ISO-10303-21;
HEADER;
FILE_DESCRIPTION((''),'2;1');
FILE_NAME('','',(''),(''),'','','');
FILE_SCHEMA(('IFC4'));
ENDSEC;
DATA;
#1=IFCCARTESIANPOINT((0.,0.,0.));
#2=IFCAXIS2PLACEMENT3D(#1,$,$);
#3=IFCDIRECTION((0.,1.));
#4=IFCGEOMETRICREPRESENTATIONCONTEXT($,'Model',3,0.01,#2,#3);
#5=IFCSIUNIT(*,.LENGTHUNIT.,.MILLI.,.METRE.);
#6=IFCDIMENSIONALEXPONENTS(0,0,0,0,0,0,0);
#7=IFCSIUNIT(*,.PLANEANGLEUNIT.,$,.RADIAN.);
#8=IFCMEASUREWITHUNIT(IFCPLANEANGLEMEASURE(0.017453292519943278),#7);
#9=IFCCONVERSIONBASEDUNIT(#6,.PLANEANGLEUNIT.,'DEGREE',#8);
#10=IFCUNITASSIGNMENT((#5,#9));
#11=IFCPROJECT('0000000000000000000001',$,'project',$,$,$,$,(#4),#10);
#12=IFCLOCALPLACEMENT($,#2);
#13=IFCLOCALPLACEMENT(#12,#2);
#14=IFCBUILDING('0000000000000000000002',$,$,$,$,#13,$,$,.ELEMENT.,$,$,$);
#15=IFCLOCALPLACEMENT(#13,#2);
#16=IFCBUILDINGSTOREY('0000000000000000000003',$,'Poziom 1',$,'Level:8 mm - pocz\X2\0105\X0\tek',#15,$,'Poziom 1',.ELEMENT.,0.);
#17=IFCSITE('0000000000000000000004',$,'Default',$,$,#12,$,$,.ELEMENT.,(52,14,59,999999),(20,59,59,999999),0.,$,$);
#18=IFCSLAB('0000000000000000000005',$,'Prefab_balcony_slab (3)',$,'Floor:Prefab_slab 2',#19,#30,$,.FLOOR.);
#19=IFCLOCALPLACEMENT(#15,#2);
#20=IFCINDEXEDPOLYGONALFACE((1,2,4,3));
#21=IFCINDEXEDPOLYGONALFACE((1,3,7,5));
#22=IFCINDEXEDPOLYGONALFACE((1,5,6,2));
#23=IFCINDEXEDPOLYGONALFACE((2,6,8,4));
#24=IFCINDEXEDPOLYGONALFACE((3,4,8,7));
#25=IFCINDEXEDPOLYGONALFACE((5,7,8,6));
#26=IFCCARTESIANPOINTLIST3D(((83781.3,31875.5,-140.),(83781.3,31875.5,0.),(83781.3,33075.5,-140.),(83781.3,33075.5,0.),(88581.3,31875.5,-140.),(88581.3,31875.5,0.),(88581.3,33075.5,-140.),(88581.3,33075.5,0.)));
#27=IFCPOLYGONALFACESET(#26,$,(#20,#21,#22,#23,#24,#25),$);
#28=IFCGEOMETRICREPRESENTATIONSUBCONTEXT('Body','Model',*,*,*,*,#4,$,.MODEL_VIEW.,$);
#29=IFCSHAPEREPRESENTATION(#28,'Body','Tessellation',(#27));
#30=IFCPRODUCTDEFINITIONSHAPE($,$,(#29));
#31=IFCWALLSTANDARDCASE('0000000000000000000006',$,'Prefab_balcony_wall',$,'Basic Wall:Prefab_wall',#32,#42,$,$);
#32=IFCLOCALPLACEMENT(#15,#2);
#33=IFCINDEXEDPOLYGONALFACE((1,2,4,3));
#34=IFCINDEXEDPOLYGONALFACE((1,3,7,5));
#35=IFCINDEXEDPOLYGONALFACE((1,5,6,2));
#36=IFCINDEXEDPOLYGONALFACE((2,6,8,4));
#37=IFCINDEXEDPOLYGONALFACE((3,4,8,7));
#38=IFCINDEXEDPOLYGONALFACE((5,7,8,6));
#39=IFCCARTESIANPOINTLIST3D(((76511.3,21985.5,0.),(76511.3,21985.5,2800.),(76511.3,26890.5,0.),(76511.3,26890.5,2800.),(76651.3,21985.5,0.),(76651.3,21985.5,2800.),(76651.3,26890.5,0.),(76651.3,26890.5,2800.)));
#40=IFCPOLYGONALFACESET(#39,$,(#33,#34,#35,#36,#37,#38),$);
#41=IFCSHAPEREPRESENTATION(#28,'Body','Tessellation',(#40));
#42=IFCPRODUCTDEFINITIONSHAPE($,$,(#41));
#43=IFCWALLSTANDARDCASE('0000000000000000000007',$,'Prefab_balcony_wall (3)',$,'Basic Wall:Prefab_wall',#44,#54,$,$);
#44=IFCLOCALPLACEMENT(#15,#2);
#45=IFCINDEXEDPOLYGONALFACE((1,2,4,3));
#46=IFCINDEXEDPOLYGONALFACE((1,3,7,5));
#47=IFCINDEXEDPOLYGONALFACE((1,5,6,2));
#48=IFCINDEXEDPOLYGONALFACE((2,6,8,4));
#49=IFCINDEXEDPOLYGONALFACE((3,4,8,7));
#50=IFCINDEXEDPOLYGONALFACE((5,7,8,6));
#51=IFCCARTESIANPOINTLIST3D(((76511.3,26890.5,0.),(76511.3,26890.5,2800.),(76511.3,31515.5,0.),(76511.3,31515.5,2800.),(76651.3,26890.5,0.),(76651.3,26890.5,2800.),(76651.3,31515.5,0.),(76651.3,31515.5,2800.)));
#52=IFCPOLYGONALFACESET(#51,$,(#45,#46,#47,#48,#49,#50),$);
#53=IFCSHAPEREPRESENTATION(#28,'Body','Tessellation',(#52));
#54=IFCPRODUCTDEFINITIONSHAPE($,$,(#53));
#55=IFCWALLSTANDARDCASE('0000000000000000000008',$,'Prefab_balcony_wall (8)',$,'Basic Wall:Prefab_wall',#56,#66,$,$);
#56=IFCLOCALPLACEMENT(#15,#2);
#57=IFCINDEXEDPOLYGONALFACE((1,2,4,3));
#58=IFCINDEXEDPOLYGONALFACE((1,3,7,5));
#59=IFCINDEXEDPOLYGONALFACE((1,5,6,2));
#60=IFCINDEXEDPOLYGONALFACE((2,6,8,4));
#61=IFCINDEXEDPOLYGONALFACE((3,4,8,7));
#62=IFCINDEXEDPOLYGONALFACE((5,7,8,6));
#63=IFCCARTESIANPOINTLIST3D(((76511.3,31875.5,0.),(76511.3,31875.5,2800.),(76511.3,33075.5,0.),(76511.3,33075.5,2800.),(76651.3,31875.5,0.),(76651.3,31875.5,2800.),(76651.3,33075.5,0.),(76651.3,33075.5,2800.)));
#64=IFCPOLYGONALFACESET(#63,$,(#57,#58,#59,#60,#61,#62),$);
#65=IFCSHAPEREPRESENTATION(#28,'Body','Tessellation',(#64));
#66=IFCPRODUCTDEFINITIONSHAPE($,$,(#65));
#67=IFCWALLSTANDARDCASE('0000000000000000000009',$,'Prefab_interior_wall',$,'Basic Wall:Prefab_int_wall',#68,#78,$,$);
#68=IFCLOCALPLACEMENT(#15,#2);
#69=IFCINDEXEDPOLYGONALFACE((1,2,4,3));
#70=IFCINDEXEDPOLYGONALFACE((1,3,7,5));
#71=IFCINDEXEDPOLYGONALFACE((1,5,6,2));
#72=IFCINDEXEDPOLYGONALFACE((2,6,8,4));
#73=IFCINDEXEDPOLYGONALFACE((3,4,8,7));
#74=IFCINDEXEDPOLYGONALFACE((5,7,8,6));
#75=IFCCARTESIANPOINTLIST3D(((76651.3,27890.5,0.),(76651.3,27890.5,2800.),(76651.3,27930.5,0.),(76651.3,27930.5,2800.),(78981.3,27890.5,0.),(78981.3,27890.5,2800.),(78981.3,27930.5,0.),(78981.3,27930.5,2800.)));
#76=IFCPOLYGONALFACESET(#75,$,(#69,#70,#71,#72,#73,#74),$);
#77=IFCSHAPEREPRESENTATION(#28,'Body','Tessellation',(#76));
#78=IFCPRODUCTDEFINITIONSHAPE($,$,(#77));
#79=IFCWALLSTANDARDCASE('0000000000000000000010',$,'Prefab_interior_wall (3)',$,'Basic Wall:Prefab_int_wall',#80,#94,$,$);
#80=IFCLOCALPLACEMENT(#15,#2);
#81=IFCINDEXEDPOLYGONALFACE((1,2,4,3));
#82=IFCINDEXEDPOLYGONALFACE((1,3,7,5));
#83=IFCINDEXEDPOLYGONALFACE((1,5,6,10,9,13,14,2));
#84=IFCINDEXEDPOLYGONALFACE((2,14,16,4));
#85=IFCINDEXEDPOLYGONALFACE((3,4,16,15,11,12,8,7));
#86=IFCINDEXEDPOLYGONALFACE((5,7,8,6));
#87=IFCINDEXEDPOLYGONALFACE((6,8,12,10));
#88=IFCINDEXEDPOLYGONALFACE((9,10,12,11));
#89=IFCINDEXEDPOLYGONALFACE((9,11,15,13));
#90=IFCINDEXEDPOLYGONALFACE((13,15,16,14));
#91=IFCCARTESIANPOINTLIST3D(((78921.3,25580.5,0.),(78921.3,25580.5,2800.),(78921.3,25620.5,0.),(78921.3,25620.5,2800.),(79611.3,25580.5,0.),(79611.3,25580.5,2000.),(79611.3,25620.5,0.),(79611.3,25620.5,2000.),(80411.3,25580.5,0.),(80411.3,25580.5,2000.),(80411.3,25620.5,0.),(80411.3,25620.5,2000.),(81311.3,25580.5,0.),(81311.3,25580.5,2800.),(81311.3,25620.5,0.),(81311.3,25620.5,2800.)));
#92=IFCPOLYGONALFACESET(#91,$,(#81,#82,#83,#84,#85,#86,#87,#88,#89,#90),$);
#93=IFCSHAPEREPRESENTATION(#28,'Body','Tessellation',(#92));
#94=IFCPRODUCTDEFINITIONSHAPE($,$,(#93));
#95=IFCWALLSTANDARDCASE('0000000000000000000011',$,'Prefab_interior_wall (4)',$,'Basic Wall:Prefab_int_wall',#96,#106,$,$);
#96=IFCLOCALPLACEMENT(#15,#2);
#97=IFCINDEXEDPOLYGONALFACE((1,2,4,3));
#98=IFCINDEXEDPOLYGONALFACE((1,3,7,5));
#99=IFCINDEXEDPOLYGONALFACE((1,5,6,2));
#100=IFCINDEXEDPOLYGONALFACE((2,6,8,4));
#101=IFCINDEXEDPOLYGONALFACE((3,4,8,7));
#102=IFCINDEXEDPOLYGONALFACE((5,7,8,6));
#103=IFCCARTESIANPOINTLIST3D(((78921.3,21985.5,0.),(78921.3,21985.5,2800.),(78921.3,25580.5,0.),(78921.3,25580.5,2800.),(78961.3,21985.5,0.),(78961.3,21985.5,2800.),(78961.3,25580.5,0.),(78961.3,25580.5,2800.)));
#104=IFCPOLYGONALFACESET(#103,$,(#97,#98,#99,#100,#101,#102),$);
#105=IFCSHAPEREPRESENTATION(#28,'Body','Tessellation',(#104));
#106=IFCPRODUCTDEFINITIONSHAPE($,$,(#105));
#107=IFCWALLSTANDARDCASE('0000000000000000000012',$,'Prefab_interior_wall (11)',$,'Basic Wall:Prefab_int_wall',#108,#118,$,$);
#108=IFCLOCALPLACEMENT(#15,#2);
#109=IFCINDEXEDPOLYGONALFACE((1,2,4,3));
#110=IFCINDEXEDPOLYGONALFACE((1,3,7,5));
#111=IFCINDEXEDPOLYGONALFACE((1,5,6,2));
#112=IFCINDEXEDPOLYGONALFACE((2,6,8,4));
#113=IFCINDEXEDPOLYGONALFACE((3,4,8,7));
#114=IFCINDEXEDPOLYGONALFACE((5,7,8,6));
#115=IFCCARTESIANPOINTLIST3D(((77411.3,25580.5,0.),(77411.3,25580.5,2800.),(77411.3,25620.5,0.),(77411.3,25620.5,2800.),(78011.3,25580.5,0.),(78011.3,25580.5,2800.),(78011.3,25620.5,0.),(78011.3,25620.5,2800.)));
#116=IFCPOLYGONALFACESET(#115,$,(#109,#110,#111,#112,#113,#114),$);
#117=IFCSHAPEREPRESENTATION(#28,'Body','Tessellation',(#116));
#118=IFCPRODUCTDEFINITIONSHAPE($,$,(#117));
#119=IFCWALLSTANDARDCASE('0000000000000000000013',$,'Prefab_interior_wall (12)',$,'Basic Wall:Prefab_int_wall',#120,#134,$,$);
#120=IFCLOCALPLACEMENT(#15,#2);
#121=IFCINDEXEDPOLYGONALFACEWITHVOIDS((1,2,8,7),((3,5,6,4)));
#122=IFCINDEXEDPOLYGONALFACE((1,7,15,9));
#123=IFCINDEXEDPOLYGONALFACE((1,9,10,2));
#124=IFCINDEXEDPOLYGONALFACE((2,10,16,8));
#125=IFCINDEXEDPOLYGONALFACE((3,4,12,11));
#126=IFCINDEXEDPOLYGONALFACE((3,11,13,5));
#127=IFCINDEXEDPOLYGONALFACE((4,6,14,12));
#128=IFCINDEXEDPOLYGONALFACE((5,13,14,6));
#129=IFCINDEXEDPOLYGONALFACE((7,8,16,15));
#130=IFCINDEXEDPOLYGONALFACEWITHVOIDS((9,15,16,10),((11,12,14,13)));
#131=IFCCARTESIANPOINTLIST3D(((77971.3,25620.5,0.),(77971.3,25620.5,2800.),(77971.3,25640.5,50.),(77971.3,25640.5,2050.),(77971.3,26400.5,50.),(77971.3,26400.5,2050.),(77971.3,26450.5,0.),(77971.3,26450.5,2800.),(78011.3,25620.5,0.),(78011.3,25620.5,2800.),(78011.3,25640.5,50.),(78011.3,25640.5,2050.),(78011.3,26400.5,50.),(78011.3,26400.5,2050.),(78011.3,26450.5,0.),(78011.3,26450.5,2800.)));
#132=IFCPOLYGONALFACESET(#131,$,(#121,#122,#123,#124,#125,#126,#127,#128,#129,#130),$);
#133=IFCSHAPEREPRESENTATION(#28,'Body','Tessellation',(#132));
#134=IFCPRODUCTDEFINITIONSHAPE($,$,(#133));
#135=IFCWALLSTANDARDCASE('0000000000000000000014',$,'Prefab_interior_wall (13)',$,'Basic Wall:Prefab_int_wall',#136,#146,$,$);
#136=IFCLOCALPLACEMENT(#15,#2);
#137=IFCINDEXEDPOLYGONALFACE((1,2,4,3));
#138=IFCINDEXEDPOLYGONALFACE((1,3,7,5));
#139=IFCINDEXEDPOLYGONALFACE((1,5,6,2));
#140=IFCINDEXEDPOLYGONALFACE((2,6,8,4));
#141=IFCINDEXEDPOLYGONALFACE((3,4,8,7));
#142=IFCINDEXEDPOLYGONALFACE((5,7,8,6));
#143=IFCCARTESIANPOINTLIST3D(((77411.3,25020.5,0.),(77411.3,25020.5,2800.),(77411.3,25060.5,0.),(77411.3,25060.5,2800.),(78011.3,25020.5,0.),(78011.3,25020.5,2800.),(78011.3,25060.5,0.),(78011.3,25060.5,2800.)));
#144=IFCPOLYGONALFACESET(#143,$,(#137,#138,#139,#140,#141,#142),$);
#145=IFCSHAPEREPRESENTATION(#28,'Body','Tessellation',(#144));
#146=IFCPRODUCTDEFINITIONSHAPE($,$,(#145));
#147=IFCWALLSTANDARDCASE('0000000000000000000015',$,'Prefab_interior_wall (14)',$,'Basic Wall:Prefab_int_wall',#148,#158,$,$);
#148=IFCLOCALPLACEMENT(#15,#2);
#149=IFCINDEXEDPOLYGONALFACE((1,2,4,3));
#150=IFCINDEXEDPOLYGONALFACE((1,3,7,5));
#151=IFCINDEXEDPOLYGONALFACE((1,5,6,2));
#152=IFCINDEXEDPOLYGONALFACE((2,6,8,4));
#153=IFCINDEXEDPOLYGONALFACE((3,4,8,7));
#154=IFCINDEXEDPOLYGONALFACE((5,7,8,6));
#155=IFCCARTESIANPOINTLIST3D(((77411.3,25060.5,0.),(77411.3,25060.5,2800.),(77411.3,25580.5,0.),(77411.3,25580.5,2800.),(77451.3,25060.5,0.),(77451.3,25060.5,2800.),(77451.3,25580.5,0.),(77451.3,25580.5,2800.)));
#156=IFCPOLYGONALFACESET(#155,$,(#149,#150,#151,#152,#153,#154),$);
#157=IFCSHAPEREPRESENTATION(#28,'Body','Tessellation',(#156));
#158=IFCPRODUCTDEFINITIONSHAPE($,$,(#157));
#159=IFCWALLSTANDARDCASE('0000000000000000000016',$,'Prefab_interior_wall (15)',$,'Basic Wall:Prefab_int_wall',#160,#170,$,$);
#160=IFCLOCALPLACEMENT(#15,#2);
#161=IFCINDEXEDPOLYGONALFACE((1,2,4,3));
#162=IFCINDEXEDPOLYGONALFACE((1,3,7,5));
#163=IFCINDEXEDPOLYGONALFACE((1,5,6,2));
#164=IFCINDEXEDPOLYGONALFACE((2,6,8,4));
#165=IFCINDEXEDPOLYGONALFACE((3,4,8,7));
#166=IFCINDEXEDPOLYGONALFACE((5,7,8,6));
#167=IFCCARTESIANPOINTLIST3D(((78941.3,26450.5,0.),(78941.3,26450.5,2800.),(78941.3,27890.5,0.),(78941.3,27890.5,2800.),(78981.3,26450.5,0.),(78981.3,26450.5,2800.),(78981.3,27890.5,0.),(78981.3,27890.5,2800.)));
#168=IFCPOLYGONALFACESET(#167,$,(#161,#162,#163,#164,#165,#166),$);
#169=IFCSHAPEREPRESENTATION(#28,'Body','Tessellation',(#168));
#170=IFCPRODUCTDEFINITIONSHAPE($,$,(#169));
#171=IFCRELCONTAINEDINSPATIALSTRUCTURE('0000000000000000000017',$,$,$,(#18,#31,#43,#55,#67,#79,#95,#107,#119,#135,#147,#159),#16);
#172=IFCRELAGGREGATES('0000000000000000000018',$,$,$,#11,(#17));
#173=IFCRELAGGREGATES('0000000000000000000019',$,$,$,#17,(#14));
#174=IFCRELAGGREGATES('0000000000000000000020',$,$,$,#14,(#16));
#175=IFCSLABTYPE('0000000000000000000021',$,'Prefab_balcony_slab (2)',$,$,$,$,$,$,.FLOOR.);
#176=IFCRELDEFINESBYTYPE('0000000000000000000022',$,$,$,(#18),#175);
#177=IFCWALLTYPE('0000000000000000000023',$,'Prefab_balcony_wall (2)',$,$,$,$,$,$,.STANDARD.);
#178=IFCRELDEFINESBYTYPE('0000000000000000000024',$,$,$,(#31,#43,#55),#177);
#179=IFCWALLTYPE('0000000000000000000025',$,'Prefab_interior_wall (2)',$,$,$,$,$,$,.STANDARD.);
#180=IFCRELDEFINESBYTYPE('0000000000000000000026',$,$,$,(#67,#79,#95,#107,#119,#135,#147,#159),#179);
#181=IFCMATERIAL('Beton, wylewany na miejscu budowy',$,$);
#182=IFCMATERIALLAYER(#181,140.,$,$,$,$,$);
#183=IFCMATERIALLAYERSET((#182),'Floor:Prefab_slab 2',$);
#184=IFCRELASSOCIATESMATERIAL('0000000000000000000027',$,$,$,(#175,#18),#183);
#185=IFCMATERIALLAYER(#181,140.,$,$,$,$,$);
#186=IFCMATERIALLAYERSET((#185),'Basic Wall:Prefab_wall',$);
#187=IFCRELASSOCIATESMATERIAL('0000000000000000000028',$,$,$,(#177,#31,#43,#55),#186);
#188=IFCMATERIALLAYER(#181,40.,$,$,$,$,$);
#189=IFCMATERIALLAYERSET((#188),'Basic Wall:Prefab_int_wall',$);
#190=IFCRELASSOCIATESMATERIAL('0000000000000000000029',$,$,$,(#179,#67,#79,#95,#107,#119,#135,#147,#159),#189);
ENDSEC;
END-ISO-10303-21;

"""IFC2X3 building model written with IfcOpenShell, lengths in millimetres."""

from ifc_helpers import new_model, entity, si_unit, converted_unit, direction, frame, frame_2d, origin, origin_2d_with_axis, place, context, subcontext, project, spatial, rectangle, extrude, material, layer, layer_set, layer_usage, type_object, element, save


model = new_model("IFC2X3")

# Units and contexts
model_context = context("Model", 3, precision=0.01, world=origin(), true_north=direction((0.0, 1.0)))
body_context = subcontext(model_context, "Body", "Model", "MODEL_VIEW")
ifc_project = project(units=[si_unit("LENGTHUNIT", "METRE", prefix="MILLI"), converted_unit("PLANEANGLEUNIT", "DEGREE", entity("IfcPlaneAngleMeasure", 0.017453292519943278), si_unit("PLANEANGLEUNIT", "RADIAN"), dimensions=[0, 0, 0, 0, 0, 0, 0])], contexts=[model_context])

# Site, building, storey
site_placement = place(None, origin())
site = spatial("IfcSite", under=ifc_project, at=site_placement, Name="Default", CompositionType="ELEMENT", RefLatitude=(52, 14, 59, 999999), RefLongitude=(20, 59, 59, 999999), RefElevation=0.0)
building_placement = place(site_placement, origin())
building = spatial("IfcBuilding", under=site, at=building_placement, CompositionType="ELEMENT")
storey_placement = place(building_placement, origin())
storey = spatial("IfcBuildingStorey", under=building, at=storey_placement, Name="Poziom 1", ObjectType="Level:8 mm - początek", LongName="Poziom 1", CompositionType="ELEMENT", Elevation=0.0)

# Slab
ifc_material_1 = material(Name="Beton, wylewany na miejscu budowy")
ifc_layer_1 = layer(ifc_material_1, 140.0)
ifc_layer_set_1 = layer_set([ifc_layer_1], Name="Floor:Prefab_slab 2")
slab_type_1 = type_object("IfcSlabType", Name="Prefab_balcony_slab (2)", PredefinedType="FLOOR", material=ifc_layer_set_1)
ifc_layer_usage_1 = layer_usage(ifc_layer_set_1, "AXIS3", "POSITIVE", 0.0)
slab_1_placement = place(storey_placement, origin())
element("IfcSlab", 1, at=slab_1_placement, inside=storey, type_object=slab_type_1, material=ifc_layer_usage_1, Name="Prefab_balcony_slab (3)", ObjectType="Floor:Prefab_slab 2", PredefinedType="FLOOR", context=body_context, shape_type="SweptSolid", body=[
    extrude(rectangle(XDim=1200.0, YDim=4800.0, at=frame_2d((0.0, 0.0), x_axis=(1.0, 0.0))), frame((86181.3, 32475.5, 0.0), z_axis=(0.0, 0.0, -1.0), x_axis=(0.0, 1.0, 0.0)), (0.0, 0.0, 1.0), 140.0),
])

# Walls
ifc_layer_2 = layer(ifc_material_1, 140.0)
ifc_layer_set_2 = layer_set([ifc_layer_2], Name="Basic Wall:Prefab_wall")
ifc_layer_usage_2 = layer_usage(ifc_layer_set_2, "AXIS2", "NEGATIVE", 70.0)
wall_type_1 = type_object("IfcWallType", Name="Prefab_balcony_wall (2)", PredefinedType="STANDARD", material=ifc_layer_set_2)
wall_1_placement = place(storey_placement, frame((76581.3, 21985.5, 0.0), z_axis=(0.0, 0.0, 1.0), x_axis=(0.0, 1.0, 0.0)))
element("IfcWallStandardCase", 2, at=wall_1_placement, inside=storey, type_object=wall_type_1, material=ifc_layer_usage_2, Name="Prefab_balcony_wall", ObjectType="Basic Wall:Prefab_wall", context=body_context, shape_type="SweptSolid", body=[
    extrude(rectangle(XDim=4905.0, YDim=140.0, at=frame_2d((2452.5, 0.0), x_axis=(-1.0, 0.0))), origin(), (0.0, 0.0, 1.0), 2800.0),
])
ifc_layer_usage_3 = layer_usage(ifc_layer_set_2, "AXIS2", "NEGATIVE", 70.0)
wall_2_placement = place(storey_placement, frame((76581.3, 31515.5, 0.0), z_axis=(0.0, 0.0, 1.0), x_axis=(0.0, -1.0, 0.0)))
element("IfcWallStandardCase", 3, at=wall_2_placement, inside=storey, type_object=wall_type_1, material=ifc_layer_usage_3, Name="Prefab_balcony_wall (3)", ObjectType="Basic Wall:Prefab_wall", context=body_context, shape_type="SweptSolid", body=[
    extrude(rectangle(XDim=4625.0, YDim=140.0, at=frame_2d((2312.5, 0.0), x_axis=(-1.0, 0.0))), origin(), (0.0, 0.0, 1.0), 2800.0),
])
ifc_layer_usage_4 = layer_usage(ifc_layer_set_2, "AXIS2", "NEGATIVE", 70.0)
wall_3_placement = place(storey_placement, frame((76581.3, 33075.5, 0.0), z_axis=(0.0, 0.0, 1.0), x_axis=(0.0, -1.0, 0.0)))
element("IfcWallStandardCase", 4, at=wall_3_placement, inside=storey, type_object=wall_type_1, material=ifc_layer_usage_4, Name="Prefab_balcony_wall (8)", ObjectType="Basic Wall:Prefab_wall", context=body_context, shape_type="SweptSolid", body=[
    extrude(rectangle(XDim=1200.0, YDim=140.0, at=frame_2d((600.0, 0.0), x_axis=(-1.0, 0.0))), origin(), (0.0, 0.0, 1.0), 2800.0),
])
ifc_layer_3 = layer(ifc_material_1, 40.0)
ifc_layer_set_3 = layer_set([ifc_layer_3], Name="Basic Wall:Prefab_int_wall")
ifc_layer_usage_5 = layer_usage(ifc_layer_set_3, "AXIS2", "NEGATIVE", 20.0)
wall_type_2 = type_object("IfcWallType", Name="Prefab_interior_wall (2)", PredefinedType="STANDARD", material=ifc_layer_set_3)
wall_4_placement = place(storey_placement, frame((76651.3, 27910.5, 0.0)))
element("IfcWallStandardCase", 5, at=wall_4_placement, inside=storey, type_object=wall_type_2, material=ifc_layer_usage_5, Name="Prefab_interior_wall", ObjectType="Basic Wall:Prefab_int_wall", context=body_context, shape_type="SweptSolid", body=[
    extrude(rectangle(XDim=2330.0, YDim=40.0, at=frame_2d((1165.0, 0.0), x_axis=(-1.0, 0.0))), origin(), (0.0, 0.0, 1.0), 2800.0),
])

# Wall, opening
ifc_layer_usage_6 = layer_usage(ifc_layer_set_3, "AXIS2", "NEGATIVE", 20.0)
wall_5_placement = place(storey_placement, frame((78921.3, 25600.5, 0.0)))
wall_5 = element("IfcWallStandardCase", 6, at=wall_5_placement, inside=storey, type_object=wall_type_2, material=ifc_layer_usage_6, Name="Prefab_interior_wall (3)", ObjectType="Basic Wall:Prefab_int_wall", context=body_context, shape_type="SweptSolid", body=[
    extrude(rectangle(XDim=2390.0, YDim=40.0, at=frame_2d((1195.0, 0.0), x_axis=(-1.0, 0.0))), origin(), (0.0, 0.0, 1.0), 2800.0),
])
opening_1_placement = place(wall_5_placement, origin())
element("IfcOpeningElement", 7, at=opening_1_placement, cuts=wall_5, ObjectType="Opening", context=body_context, shape_type="SweptSolid", body=[
    extrude(rectangle(XDim=2000.0, YDim=800.0, at=frame_2d((0.0, 0.0), x_axis=(0.0, 1.0))), frame((1090.0, 20.0, 1000.0), z_axis=(0.0, -1.0, 0.0), x_axis=(1.0, 0.0, 0.0)), (0.0, 0.0, 1.0), 40.0),
])

# Walls
ifc_layer_usage_7 = layer_usage(ifc_layer_set_3, "AXIS2", "NEGATIVE", 20.0)
wall_6_placement = place(storey_placement, frame((78941.3, 25580.5, 0.0), z_axis=(0.0, 0.0, 1.0), x_axis=(0.0, -1.0, 0.0)))
element("IfcWallStandardCase", 8, at=wall_6_placement, inside=storey, type_object=wall_type_2, material=ifc_layer_usage_7, Name="Prefab_interior_wall (4)", ObjectType="Basic Wall:Prefab_int_wall", context=body_context, shape_type="SweptSolid", body=[
    extrude(rectangle(XDim=3595.0, YDim=40.0, at=frame_2d((1797.5, 0.0), x_axis=(-1.0, 0.0))), origin(), (0.0, 0.0, 1.0), 2800.0),
])
ifc_layer_usage_8 = layer_usage(ifc_layer_set_3, "AXIS2", "NEGATIVE", 20.0)
wall_7_placement = place(storey_placement, frame((77411.3, 25600.5, 0.0)))
element("IfcWallStandardCase", 9, at=wall_7_placement, inside=storey, type_object=wall_type_2, material=ifc_layer_usage_8, Name="Prefab_interior_wall (11)", ObjectType="Basic Wall:Prefab_int_wall", context=body_context, shape_type="SweptSolid", body=[
    extrude(rectangle(XDim=600.0, YDim=40.0, at=frame_2d((300.0, 0.0), x_axis=(-1.0, 0.0))), origin(), (0.0, 0.0, 1.0), 2800.0),
])

# Wall, opening
ifc_layer_usage_9 = layer_usage(ifc_layer_set_3, "AXIS2", "NEGATIVE", 20.0)
wall_8_placement = place(storey_placement, frame((77991.3, 26450.5, 0.0), z_axis=(0.0, 0.0, 1.0), x_axis=(0.0, -1.0, 0.0)))
wall_8 = element("IfcWallStandardCase", 10, at=wall_8_placement, inside=storey, type_object=wall_type_2, material=ifc_layer_usage_9, Name="Prefab_interior_wall (12)", ObjectType="Basic Wall:Prefab_int_wall", context=body_context, shape_type="SweptSolid", body=[
    extrude(rectangle(XDim=830.0, YDim=40.0, at=frame_2d((415.0, 0.0), x_axis=(-1.0, 0.0))), origin(), (0.0, 0.0, 1.0), 2800.0),
])
opening_2_placement = place(wall_8_placement, origin())
element("IfcOpeningElement", 11, at=opening_2_placement, cuts=wall_8, ObjectType="Opening", context=body_context, shape_type="SweptSolid", body=[
    extrude(rectangle(XDim=2000.0, YDim=760.0, at=origin_2d_with_axis()), frame((430.0, 20.0, 1050.0), z_axis=(0.0, -1.0, 0.0), x_axis=(0.0, 0.0, 1.0)), (0.0, 0.0, 1.0), 40.0),
])

# Walls
ifc_layer_usage_10 = layer_usage(ifc_layer_set_3, "AXIS2", "NEGATIVE", 20.0)
wall_9_placement = place(storey_placement, frame((78011.3, 25040.5, 0.0), z_axis=(0.0, 0.0, 1.0), x_axis=(-1.0, 0.0, 0.0)))
element("IfcWallStandardCase", 12, at=wall_9_placement, inside=storey, type_object=wall_type_2, material=ifc_layer_usage_10, Name="Prefab_interior_wall (13)", ObjectType="Basic Wall:Prefab_int_wall", context=body_context, shape_type="SweptSolid", body=[
    extrude(rectangle(XDim=600.0, YDim=40.0, at=frame_2d((300.0, 0.0), x_axis=(-1.0, 0.0))), origin(), (0.0, 0.0, 1.0), 2800.0),
])
ifc_layer_usage_11 = layer_usage(ifc_layer_set_3, "AXIS2", "NEGATIVE", 20.0)
wall_10_placement = place(storey_placement, frame((77431.3, 25060.5, 0.0), z_axis=(0.0, 0.0, 1.0), x_axis=(0.0, 1.0, 0.0)))
element("IfcWallStandardCase", 13, at=wall_10_placement, inside=storey, type_object=wall_type_2, material=ifc_layer_usage_11, Name="Prefab_interior_wall (14)", ObjectType="Basic Wall:Prefab_int_wall", context=body_context, shape_type="SweptSolid", body=[
    extrude(rectangle(XDim=520.0, YDim=40.0, at=frame_2d((260.0, 0.0), x_axis=(-1.0, 0.0))), origin(), (0.0, 0.0, 1.0), 2800.0),
])
ifc_layer_usage_12 = layer_usage(ifc_layer_set_3, "AXIS2", "NEGATIVE", 20.0)
wall_11_placement = place(storey_placement, frame((78961.3, 27890.5, 0.0), z_axis=(0.0, 0.0, 1.0), x_axis=(0.0, -1.0, 0.0)))
element("IfcWallStandardCase", 14, at=wall_11_placement, inside=storey, type_object=wall_type_2, material=ifc_layer_usage_12, Name="Prefab_interior_wall (15)", ObjectType="Basic Wall:Prefab_int_wall", context=body_context, shape_type="SweptSolid", body=[
    extrude(rectangle(XDim=1440.0, YDim=40.0, at=frame_2d((720.0, 0.0), x_axis=(-1.0, 0.0))), origin(), (0.0, 0.0, 1.0), 2800.0),
])

save(model, "model.ifc")
